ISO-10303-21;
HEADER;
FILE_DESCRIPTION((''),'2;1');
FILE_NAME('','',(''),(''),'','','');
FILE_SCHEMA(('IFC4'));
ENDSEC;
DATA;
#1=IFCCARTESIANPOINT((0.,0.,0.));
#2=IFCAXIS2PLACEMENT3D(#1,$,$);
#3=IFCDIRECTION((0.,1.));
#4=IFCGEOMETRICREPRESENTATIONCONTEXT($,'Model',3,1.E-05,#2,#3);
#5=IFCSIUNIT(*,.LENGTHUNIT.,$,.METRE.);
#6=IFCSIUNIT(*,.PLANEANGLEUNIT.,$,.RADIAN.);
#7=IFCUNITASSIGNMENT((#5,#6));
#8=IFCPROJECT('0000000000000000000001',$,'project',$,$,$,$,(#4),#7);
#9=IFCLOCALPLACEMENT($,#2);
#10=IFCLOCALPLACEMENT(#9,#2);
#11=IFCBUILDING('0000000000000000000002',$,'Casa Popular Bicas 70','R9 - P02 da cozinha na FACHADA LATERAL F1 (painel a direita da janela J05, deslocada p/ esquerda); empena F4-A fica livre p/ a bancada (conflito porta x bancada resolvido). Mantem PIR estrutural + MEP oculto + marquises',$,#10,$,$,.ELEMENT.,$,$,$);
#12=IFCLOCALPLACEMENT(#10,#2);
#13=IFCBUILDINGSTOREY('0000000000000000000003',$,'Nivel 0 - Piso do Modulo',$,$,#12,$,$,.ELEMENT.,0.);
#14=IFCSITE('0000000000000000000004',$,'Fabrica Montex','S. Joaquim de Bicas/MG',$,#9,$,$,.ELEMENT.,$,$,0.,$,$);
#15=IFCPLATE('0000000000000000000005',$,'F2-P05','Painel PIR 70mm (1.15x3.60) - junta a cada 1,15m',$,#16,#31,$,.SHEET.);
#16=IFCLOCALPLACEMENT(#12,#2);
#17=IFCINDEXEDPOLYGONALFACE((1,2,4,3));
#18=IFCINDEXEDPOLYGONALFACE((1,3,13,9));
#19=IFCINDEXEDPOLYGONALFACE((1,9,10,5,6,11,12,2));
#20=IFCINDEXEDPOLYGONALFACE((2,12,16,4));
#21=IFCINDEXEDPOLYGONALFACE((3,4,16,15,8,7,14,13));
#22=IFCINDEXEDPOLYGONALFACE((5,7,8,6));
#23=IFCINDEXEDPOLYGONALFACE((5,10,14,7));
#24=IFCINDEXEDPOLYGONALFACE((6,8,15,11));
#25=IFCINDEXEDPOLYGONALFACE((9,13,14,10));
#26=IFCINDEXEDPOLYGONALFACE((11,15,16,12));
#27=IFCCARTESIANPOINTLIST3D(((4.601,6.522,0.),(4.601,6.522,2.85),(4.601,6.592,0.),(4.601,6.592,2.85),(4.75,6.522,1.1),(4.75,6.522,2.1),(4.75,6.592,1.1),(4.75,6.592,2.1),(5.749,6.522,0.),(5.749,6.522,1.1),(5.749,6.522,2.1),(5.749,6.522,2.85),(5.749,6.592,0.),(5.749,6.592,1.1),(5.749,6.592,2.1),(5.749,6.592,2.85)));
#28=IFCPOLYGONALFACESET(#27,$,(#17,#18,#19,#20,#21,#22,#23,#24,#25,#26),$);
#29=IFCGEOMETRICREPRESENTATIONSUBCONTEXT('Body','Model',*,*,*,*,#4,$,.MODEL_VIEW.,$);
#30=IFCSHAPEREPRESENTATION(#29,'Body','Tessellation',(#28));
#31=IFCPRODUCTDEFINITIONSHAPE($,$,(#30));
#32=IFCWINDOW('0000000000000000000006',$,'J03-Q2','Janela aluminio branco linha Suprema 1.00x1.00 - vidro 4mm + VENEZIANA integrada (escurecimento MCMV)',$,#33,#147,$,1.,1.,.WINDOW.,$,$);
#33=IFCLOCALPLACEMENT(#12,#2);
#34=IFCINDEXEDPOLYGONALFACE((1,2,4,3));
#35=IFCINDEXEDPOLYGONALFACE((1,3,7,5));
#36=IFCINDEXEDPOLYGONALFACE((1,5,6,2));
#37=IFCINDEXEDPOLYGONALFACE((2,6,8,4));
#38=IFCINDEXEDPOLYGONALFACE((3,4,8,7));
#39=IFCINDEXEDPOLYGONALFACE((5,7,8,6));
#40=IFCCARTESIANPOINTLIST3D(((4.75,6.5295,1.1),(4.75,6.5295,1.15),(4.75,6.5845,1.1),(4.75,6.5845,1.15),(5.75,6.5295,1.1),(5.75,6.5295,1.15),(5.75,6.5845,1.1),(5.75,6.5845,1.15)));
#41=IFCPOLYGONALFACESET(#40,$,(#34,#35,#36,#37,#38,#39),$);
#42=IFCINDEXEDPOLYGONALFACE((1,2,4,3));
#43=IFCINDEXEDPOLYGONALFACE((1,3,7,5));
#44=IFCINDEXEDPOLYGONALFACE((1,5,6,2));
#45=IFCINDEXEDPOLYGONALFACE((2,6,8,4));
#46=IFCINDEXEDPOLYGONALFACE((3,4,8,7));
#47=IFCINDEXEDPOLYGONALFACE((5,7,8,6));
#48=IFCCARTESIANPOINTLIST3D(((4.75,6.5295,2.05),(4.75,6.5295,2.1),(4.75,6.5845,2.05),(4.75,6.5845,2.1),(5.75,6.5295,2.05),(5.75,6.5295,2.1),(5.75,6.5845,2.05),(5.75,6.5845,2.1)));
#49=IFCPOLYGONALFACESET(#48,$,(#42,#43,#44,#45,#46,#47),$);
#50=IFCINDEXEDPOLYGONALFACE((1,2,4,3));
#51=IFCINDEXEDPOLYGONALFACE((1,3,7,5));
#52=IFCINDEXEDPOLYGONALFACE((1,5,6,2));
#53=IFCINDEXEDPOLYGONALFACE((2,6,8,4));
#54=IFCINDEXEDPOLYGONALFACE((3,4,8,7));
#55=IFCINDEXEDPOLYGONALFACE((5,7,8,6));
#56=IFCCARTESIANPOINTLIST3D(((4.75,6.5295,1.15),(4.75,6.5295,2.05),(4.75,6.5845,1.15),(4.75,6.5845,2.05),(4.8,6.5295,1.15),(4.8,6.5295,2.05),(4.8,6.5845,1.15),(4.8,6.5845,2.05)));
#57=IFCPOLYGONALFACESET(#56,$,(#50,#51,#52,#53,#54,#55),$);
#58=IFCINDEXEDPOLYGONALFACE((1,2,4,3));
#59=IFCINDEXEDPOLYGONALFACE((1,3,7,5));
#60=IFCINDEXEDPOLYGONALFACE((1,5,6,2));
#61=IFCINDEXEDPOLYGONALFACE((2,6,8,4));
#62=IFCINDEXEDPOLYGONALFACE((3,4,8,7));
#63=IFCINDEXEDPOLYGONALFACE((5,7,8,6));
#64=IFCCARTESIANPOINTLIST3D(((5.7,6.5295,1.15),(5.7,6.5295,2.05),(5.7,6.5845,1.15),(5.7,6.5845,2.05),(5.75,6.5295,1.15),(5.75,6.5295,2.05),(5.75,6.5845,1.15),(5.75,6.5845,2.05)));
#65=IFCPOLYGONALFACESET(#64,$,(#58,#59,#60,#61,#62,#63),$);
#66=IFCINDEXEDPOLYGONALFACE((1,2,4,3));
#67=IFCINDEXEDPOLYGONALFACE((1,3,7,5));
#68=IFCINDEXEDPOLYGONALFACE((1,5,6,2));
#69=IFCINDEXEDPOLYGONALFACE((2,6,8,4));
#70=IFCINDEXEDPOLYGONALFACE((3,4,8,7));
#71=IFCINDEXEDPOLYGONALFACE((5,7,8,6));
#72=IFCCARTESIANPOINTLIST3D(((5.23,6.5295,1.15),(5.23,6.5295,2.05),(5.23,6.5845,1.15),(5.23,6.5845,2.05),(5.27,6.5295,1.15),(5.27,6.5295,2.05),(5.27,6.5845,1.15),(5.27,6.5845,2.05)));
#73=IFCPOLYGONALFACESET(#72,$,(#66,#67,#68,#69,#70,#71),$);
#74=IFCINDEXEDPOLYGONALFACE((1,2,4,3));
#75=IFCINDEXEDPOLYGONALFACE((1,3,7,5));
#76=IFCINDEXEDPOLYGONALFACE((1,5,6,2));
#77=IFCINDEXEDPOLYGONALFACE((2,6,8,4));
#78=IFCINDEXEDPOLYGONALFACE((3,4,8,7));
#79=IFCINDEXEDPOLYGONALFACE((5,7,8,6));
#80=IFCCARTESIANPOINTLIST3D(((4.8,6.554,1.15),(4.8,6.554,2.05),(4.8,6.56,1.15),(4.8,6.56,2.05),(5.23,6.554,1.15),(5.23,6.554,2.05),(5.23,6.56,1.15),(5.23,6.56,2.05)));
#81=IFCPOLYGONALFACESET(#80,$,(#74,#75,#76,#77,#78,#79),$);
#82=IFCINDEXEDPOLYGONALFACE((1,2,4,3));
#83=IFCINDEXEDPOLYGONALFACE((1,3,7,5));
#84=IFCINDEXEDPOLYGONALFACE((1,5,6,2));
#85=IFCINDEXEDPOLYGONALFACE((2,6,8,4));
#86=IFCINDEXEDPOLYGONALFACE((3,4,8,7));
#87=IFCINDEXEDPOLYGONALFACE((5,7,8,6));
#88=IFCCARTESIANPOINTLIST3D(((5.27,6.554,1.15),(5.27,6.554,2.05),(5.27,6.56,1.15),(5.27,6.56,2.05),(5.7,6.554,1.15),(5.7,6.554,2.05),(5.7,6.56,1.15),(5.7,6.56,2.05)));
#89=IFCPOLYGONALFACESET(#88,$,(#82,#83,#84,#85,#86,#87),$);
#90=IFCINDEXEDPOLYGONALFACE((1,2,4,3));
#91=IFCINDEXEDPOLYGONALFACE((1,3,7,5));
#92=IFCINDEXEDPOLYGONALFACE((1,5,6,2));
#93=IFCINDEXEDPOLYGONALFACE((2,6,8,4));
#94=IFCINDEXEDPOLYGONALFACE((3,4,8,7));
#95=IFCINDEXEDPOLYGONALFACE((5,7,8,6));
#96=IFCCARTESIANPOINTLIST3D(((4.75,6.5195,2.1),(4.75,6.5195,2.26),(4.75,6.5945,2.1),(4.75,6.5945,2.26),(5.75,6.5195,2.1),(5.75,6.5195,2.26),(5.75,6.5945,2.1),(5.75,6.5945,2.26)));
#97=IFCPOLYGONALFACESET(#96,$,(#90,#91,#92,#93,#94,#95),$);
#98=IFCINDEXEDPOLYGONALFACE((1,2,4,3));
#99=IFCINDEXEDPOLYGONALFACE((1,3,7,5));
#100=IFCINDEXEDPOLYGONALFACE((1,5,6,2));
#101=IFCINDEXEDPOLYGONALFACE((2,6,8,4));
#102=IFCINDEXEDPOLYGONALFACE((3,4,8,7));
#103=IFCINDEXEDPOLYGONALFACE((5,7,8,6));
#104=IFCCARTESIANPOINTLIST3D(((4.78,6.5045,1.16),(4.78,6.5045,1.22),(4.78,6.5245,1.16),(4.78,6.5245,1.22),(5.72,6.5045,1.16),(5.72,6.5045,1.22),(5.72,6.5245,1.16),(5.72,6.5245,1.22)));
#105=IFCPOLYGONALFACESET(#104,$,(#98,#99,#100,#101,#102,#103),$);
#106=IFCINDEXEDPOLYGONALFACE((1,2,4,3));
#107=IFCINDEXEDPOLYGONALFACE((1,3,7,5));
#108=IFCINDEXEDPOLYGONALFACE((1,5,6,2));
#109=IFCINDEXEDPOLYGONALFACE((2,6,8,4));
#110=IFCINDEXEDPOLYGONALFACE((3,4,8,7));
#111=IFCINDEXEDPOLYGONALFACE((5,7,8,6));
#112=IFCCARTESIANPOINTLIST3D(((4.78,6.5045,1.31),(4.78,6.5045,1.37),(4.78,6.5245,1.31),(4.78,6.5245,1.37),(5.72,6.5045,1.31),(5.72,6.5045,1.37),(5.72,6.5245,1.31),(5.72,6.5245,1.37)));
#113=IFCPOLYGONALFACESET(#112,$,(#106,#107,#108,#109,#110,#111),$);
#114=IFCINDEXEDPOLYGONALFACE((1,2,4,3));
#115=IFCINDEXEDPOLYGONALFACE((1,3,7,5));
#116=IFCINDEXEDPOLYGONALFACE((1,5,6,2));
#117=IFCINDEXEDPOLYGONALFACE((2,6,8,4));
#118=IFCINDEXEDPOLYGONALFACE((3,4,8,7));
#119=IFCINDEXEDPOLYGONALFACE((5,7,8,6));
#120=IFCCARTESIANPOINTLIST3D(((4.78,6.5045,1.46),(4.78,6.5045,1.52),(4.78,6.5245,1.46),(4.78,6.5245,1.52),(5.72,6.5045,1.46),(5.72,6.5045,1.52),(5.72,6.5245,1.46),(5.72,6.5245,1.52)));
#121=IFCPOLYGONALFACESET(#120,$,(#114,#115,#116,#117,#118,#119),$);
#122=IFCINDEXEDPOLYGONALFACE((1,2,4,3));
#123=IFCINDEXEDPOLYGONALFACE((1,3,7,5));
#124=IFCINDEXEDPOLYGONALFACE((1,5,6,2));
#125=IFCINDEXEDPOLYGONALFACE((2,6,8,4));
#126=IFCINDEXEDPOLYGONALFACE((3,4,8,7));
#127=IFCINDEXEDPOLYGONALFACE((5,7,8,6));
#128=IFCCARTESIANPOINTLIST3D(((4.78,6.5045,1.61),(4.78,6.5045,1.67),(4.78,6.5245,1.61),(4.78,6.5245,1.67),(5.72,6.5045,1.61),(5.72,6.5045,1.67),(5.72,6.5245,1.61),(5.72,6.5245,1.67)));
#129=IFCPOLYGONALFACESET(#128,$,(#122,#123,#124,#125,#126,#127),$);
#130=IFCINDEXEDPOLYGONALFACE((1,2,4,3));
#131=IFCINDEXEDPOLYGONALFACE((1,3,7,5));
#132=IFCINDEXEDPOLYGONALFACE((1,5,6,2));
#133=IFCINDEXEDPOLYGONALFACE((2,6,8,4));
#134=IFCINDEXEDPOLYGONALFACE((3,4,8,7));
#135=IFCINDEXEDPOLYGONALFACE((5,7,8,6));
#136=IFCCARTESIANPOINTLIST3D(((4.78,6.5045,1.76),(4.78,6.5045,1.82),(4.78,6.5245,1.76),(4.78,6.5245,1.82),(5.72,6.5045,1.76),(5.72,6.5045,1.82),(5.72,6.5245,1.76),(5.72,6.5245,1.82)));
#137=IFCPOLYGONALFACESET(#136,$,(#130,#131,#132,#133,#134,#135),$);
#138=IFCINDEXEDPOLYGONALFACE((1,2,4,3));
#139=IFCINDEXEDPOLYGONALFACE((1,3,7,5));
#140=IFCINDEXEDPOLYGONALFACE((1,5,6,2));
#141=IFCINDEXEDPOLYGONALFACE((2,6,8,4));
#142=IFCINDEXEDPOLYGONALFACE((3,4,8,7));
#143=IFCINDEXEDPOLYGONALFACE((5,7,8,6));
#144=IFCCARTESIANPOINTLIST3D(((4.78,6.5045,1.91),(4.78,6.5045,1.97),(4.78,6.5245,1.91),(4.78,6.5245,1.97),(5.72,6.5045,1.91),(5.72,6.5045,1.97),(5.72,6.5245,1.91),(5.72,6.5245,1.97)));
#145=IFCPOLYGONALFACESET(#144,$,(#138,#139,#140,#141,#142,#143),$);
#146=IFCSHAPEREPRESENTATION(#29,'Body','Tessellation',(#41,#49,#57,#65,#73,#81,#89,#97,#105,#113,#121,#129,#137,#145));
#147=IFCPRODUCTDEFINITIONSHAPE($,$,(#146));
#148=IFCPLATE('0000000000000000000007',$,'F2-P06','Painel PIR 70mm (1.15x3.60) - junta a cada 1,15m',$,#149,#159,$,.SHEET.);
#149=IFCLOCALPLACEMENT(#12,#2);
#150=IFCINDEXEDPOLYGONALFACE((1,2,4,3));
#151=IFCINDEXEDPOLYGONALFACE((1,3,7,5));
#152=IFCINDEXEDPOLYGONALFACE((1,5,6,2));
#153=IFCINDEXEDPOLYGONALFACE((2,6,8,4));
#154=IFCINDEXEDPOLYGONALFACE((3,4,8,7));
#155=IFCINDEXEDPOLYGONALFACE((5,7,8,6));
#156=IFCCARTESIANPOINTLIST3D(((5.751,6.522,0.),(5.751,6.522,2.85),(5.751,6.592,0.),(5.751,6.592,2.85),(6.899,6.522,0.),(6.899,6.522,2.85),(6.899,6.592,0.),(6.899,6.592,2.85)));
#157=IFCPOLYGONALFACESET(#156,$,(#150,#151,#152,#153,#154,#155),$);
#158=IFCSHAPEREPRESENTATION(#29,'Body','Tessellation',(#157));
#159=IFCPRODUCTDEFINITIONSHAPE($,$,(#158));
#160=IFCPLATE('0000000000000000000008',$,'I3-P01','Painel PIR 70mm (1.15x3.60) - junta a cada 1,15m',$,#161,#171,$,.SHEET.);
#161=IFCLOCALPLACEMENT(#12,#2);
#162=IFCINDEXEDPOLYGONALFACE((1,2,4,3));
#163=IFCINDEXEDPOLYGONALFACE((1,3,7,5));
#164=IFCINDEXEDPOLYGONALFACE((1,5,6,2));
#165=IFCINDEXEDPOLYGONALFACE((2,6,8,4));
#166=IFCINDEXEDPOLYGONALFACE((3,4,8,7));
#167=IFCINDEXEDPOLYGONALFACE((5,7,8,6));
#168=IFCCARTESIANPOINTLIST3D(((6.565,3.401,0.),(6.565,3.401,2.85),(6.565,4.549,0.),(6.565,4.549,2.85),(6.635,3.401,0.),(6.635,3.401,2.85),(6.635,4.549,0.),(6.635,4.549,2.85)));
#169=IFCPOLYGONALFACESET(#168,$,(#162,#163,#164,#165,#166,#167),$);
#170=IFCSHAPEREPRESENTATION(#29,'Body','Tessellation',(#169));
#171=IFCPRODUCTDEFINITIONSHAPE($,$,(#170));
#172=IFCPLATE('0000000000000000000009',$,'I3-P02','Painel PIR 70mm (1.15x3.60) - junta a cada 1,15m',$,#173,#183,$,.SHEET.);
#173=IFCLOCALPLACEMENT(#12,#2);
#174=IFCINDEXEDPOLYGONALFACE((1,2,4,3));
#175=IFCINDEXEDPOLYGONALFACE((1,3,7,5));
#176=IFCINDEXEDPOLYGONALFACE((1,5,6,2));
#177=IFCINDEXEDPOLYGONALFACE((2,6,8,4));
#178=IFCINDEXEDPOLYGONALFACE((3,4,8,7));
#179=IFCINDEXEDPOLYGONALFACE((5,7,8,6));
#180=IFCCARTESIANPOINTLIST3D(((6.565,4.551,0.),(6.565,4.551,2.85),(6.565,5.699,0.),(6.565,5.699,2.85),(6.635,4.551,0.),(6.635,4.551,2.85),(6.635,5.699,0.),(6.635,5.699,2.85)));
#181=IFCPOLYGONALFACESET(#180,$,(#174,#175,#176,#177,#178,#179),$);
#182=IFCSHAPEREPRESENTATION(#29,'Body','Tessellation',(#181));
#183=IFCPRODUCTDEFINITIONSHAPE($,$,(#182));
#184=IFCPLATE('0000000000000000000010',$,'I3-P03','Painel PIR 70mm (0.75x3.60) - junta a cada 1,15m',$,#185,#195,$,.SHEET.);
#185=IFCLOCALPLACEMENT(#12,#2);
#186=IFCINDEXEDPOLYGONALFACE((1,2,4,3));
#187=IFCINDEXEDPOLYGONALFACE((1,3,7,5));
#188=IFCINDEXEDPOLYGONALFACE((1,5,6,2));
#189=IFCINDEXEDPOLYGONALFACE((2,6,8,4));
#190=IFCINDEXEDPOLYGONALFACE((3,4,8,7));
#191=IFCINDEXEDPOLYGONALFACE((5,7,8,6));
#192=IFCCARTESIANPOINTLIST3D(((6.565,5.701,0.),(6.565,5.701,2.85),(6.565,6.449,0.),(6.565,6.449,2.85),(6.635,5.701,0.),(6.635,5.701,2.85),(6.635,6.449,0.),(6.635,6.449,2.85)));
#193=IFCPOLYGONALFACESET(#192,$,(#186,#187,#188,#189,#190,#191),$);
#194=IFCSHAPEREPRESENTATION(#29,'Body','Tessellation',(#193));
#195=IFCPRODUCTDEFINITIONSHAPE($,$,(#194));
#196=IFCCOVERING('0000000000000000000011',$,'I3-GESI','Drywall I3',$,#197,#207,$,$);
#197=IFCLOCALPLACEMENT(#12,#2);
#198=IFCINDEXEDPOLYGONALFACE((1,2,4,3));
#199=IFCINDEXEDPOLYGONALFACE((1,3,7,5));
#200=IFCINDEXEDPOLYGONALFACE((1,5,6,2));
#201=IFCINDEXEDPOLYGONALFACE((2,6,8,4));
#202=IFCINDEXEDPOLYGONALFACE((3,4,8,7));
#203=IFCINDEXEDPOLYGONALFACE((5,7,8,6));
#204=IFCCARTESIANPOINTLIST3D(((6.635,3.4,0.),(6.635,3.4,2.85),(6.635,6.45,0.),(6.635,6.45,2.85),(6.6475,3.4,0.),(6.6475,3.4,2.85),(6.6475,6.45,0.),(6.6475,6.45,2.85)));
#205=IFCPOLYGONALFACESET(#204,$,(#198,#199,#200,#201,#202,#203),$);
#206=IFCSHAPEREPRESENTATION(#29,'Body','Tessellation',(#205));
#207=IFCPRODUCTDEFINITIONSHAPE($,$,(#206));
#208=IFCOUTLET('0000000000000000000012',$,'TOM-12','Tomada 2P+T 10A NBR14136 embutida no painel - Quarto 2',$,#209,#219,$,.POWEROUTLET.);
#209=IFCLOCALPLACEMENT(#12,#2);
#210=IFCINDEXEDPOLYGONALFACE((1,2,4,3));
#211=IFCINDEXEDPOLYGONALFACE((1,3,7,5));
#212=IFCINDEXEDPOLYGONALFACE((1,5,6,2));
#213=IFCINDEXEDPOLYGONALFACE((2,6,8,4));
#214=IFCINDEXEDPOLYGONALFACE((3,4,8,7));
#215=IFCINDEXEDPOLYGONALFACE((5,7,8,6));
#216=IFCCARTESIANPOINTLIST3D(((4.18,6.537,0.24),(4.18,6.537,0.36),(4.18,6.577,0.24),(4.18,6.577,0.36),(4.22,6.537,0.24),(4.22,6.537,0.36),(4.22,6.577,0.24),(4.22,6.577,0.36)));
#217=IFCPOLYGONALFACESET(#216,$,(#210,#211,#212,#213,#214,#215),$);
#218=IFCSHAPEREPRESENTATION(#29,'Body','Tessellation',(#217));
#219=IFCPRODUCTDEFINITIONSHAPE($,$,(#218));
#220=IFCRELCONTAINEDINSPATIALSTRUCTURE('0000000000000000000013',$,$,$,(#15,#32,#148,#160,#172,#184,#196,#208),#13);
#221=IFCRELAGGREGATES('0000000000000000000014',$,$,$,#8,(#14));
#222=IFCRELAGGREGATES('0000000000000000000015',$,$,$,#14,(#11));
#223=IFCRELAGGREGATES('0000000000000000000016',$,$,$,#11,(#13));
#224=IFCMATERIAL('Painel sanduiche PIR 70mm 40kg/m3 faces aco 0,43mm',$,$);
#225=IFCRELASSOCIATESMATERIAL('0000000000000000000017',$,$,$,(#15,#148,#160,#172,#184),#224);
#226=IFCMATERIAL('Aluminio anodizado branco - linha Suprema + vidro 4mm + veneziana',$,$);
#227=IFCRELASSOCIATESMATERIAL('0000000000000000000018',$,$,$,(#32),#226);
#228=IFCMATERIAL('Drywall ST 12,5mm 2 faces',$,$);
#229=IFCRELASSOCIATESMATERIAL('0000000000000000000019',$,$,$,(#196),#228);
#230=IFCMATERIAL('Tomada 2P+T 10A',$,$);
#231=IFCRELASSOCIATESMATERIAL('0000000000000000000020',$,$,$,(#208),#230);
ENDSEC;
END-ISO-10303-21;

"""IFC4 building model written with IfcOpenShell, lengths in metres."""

from ifc_helpers import new_model, si_unit, direction, frame, frame_2d, origin, origin_2d, place, context, subcontext, project, spatial, rectangle, extrude, material, element, fill, save


model = new_model("IFC4")

# Units and contexts
model_context = context("Model", 3, precision=1e-05, world=origin(), true_north=direction((0.0, 1.0)))
body_context = subcontext(model_context, "Body", "Model", "MODEL_VIEW")
ifc_project = project(units=[si_unit("LENGTHUNIT", "METRE"), si_unit("PLANEANGLEUNIT", "RADIAN")], contexts=[model_context])

# Site, building, storey
site_placement = place(None, origin())
site = spatial("IfcSite", under=ifc_project, at=site_placement, Name="Fabrica Montex", Description="S. Joaquim de Bicas/MG", CompositionType="ELEMENT", RefElevation=0.0)
building_placement = place(site_placement, origin())
building = spatial("IfcBuilding", under=site, at=building_placement, Name="Casa Popular Bicas 70", Description="R9 - P02 da cozinha na FACHADA LATERAL F1 (painel a direita da janela J05, deslocada p/ esquerda); empena F4-A fica livre p/ a bancada (conflito porta x bancada resolvido). Mantem PIR estrutural + MEP oculto + marquises", CompositionType="ELEMENT")
storey_placement = place(building_placement, origin())
storey = spatial("IfcBuildingStorey", under=building, at=storey_placement, Name="Nivel 0 - Piso do Modulo", CompositionType="ELEMENT", Elevation=0.0)

# Plate, opening, window
ifc_material_1 = material(Name="Painel sanduiche PIR 70mm 40kg/m3 faces aco 0,43mm")
plate_1_placement = place(storey_placement, frame((4.601, 6.557, 0.0), x_axis=(1.0, 0.0, 0.0)))
plate_1 = element("IfcPlate", 1, at=plate_1_placement, inside=storey, material=ifc_material_1, Name="F2-P05", Description="Painel PIR 70mm (1.15x3.60) - junta a cada 1,15m", PredefinedType="SHEET", context=body_context, shape_type="SweptSolid", body=[
    extrude(rectangle(XDim=1.148, YDim=0.07, at=frame_2d((0.574, 0.0))), origin(), (0.0, 0.0, 1.0), 2.85),
])
opening_placement = place(storey_placement, frame((5.25, 6.557, 1.1)))
opening = element("IfcOpeningElement", 2, at=opening_placement, cuts=plate_1, PredefinedType="OPENING", context=body_context, shape_type="SweptSolid", body=[
    extrude(rectangle(XDim=1.0, YDim=0.1, at=origin_2d()), origin(), (0.0, 0.0, 1.0), 1.0),
])
ifc_material_2 = material(Name="Aluminio anodizado branco - linha Suprema + vidro 4mm + veneziana")
window_placement = place(storey_placement, frame((4.75, 6.557, 1.1), x_axis=(1.0, 0.0, 0.0)))
window = element("IfcWindow", 3, at=window_placement, inside=storey, material=ifc_material_2, Name="J03-Q2", Description="Janela aluminio branco linha Suprema 1.00x1.00 - vidro 4mm + VENEZIANA integrada (escurecimento MCMV)", OverallHeight=1.0, OverallWidth=1.0, PredefinedType="WINDOW", context=body_context, shape_type="SweptSolid", body=[
    extrude(rectangle(XDim=1.0, YDim=0.055, at=frame_2d((0.5, 0.0))), origin(), (0.0, 0.0, 1.0), 0.05),
    extrude(rectangle(XDim=1.0, YDim=0.055, at=frame_2d((0.5, 0.0))), frame((0.0, 0.0, 0.95)), (0.0, 0.0, 1.0), 0.05),
    extrude(rectangle(XDim=0.05, YDim=0.055, at=frame_2d((0.025, 0.0))), frame((0.0, 0.0, 0.05)), (0.0, 0.0, 1.0), 0.9),
    extrude(rectangle(XDim=0.05, YDim=0.055, at=frame_2d((0.975, 0.0))), frame((0.0, 0.0, 0.05)), (0.0, 0.0, 1.0), 0.9),
    extrude(rectangle(XDim=0.04, YDim=0.055, at=frame_2d((0.5, 0.0))), frame((0.0, 0.0, 0.05)), (0.0, 0.0, 1.0), 0.9),
    extrude(rectangle(XDim=0.43, YDim=0.006, at=frame_2d((0.265, 0.0))), frame((0.0, 0.0, 0.05)), (0.0, 0.0, 1.0), 0.9),
    extrude(rectangle(XDim=0.43, YDim=0.006, at=frame_2d((0.735, 0.0))), frame((0.0, 0.0, 0.05)), (0.0, 0.0, 1.0), 0.9),
    extrude(rectangle(XDim=1.0, YDim=0.075, at=frame_2d((0.5, 0.0))), frame((0.0, 0.0, 1.0)), (0.0, 0.0, 1.0), 0.16),
    extrude(rectangle(XDim=0.94, YDim=0.02, at=frame_2d((0.5, -0.0425))), frame((0.0, 0.0, 0.06)), (0.0, 0.0, 1.0), 0.06),
    extrude(rectangle(XDim=0.94, YDim=0.02, at=frame_2d((0.5, -0.0425))), frame((0.0, 0.0, 0.21)), (0.0, 0.0, 1.0), 0.06),
    extrude(rectangle(XDim=0.94, YDim=0.02, at=frame_2d((0.5, -0.0425))), frame((0.0, 0.0, 0.36)), (0.0, 0.0, 1.0), 0.06),
    extrude(rectangle(XDim=0.94, YDim=0.02, at=frame_2d((0.5, -0.0425))), frame((0.0, 0.0, 0.51)), (0.0, 0.0, 1.0), 0.06),
    extrude(rectangle(XDim=0.94, YDim=0.02, at=frame_2d((0.5, -0.0425))), frame((0.0, 0.0, 0.66)), (0.0, 0.0, 1.0), 0.06),
    extrude(rectangle(XDim=0.94, YDim=0.02, at=frame_2d((0.5, -0.0425))), frame((0.0, 0.0, 0.81)), (0.0, 0.0, 1.0), 0.06),
])
fill(opening, window)

# Plates
for number, where, x_axis, name in (
    (4, (5.751, 6.557, 0.0), (1.0, 0.0, 0.0), "F2-P06"),
    (5, (6.6, 3.401, 0.0), (0.0, 1.0, 0.0), "I3-P01"),
    (6, (6.6, 4.551, 0.0), (0.0, 1.0, 0.0), "I3-P02"),
):
    element("IfcPlate", number, at=place(storey_placement, frame(where, x_axis=x_axis)), inside=storey, material=ifc_material_1, Name=name, Description="Painel PIR 70mm (1.15x3.60) - junta a cada 1,15m", PredefinedType="SHEET", context=body_context, shape_type="SweptSolid", body=[
        extrude(rectangle(XDim=1.148, YDim=0.07, at=frame_2d((0.574, 0.0))), origin(), (0.0, 0.0, 1.0), 2.85),
    ])
plate_2_placement = place(storey_placement, frame((6.6, 5.701, 0.0), x_axis=(0.0, 1.0, 0.0)))
element("IfcPlate", 7, at=plate_2_placement, inside=storey, material=ifc_material_1, Name="I3-P03", Description="Painel PIR 70mm (0.75x3.60) - junta a cada 1,15m", PredefinedType="SHEET", context=body_context, shape_type="SweptSolid", body=[
    extrude(rectangle(XDim=0.748, YDim=0.07, at=frame_2d((0.374, 0.0))), origin(), (0.0, 0.0, 1.0), 2.85),
])

# Covering
ifc_material_3 = material(Name="Drywall ST 12,5mm 2 faces")
covering_placement = place(storey_placement, frame((6.6412, 3.4, 0.0), x_axis=(0.0, 1.0, 0.0)))
element("IfcCovering", 8, at=covering_placement, inside=storey, material=ifc_material_3, Name="I3-GESI", Description="Drywall I3", context=body_context, shape_type="SweptSolid", body=[
    extrude(rectangle(XDim=3.05, YDim=0.0125, at=frame_2d((1.525, 0.0))), origin(), (0.0, 0.0, 1.0), 2.85),
])

# Outlet
ifc_material_4 = material(Name="Tomada 2P+T 10A")
outlet_1_placement = place(storey_placement, frame((4.18, 6.537, 0.24)))
element("IfcOutlet", 9, at=outlet_1_placement, inside=storey, material=ifc_material_4, Name="TOM-12", Description="Tomada 2P+T 10A NBR14136 embutida no painel - Quarto 2", PredefinedType="POWEROUTLET", context=body_context, shape_type="SweptSolid", body=[
    extrude(rectangle(XDim=0.04, YDim=0.04, at=frame_2d((0.02, 0.02))), origin(), (0.0, 0.0, 1.0), 0.12),
])

save(model, "model.ifc")
